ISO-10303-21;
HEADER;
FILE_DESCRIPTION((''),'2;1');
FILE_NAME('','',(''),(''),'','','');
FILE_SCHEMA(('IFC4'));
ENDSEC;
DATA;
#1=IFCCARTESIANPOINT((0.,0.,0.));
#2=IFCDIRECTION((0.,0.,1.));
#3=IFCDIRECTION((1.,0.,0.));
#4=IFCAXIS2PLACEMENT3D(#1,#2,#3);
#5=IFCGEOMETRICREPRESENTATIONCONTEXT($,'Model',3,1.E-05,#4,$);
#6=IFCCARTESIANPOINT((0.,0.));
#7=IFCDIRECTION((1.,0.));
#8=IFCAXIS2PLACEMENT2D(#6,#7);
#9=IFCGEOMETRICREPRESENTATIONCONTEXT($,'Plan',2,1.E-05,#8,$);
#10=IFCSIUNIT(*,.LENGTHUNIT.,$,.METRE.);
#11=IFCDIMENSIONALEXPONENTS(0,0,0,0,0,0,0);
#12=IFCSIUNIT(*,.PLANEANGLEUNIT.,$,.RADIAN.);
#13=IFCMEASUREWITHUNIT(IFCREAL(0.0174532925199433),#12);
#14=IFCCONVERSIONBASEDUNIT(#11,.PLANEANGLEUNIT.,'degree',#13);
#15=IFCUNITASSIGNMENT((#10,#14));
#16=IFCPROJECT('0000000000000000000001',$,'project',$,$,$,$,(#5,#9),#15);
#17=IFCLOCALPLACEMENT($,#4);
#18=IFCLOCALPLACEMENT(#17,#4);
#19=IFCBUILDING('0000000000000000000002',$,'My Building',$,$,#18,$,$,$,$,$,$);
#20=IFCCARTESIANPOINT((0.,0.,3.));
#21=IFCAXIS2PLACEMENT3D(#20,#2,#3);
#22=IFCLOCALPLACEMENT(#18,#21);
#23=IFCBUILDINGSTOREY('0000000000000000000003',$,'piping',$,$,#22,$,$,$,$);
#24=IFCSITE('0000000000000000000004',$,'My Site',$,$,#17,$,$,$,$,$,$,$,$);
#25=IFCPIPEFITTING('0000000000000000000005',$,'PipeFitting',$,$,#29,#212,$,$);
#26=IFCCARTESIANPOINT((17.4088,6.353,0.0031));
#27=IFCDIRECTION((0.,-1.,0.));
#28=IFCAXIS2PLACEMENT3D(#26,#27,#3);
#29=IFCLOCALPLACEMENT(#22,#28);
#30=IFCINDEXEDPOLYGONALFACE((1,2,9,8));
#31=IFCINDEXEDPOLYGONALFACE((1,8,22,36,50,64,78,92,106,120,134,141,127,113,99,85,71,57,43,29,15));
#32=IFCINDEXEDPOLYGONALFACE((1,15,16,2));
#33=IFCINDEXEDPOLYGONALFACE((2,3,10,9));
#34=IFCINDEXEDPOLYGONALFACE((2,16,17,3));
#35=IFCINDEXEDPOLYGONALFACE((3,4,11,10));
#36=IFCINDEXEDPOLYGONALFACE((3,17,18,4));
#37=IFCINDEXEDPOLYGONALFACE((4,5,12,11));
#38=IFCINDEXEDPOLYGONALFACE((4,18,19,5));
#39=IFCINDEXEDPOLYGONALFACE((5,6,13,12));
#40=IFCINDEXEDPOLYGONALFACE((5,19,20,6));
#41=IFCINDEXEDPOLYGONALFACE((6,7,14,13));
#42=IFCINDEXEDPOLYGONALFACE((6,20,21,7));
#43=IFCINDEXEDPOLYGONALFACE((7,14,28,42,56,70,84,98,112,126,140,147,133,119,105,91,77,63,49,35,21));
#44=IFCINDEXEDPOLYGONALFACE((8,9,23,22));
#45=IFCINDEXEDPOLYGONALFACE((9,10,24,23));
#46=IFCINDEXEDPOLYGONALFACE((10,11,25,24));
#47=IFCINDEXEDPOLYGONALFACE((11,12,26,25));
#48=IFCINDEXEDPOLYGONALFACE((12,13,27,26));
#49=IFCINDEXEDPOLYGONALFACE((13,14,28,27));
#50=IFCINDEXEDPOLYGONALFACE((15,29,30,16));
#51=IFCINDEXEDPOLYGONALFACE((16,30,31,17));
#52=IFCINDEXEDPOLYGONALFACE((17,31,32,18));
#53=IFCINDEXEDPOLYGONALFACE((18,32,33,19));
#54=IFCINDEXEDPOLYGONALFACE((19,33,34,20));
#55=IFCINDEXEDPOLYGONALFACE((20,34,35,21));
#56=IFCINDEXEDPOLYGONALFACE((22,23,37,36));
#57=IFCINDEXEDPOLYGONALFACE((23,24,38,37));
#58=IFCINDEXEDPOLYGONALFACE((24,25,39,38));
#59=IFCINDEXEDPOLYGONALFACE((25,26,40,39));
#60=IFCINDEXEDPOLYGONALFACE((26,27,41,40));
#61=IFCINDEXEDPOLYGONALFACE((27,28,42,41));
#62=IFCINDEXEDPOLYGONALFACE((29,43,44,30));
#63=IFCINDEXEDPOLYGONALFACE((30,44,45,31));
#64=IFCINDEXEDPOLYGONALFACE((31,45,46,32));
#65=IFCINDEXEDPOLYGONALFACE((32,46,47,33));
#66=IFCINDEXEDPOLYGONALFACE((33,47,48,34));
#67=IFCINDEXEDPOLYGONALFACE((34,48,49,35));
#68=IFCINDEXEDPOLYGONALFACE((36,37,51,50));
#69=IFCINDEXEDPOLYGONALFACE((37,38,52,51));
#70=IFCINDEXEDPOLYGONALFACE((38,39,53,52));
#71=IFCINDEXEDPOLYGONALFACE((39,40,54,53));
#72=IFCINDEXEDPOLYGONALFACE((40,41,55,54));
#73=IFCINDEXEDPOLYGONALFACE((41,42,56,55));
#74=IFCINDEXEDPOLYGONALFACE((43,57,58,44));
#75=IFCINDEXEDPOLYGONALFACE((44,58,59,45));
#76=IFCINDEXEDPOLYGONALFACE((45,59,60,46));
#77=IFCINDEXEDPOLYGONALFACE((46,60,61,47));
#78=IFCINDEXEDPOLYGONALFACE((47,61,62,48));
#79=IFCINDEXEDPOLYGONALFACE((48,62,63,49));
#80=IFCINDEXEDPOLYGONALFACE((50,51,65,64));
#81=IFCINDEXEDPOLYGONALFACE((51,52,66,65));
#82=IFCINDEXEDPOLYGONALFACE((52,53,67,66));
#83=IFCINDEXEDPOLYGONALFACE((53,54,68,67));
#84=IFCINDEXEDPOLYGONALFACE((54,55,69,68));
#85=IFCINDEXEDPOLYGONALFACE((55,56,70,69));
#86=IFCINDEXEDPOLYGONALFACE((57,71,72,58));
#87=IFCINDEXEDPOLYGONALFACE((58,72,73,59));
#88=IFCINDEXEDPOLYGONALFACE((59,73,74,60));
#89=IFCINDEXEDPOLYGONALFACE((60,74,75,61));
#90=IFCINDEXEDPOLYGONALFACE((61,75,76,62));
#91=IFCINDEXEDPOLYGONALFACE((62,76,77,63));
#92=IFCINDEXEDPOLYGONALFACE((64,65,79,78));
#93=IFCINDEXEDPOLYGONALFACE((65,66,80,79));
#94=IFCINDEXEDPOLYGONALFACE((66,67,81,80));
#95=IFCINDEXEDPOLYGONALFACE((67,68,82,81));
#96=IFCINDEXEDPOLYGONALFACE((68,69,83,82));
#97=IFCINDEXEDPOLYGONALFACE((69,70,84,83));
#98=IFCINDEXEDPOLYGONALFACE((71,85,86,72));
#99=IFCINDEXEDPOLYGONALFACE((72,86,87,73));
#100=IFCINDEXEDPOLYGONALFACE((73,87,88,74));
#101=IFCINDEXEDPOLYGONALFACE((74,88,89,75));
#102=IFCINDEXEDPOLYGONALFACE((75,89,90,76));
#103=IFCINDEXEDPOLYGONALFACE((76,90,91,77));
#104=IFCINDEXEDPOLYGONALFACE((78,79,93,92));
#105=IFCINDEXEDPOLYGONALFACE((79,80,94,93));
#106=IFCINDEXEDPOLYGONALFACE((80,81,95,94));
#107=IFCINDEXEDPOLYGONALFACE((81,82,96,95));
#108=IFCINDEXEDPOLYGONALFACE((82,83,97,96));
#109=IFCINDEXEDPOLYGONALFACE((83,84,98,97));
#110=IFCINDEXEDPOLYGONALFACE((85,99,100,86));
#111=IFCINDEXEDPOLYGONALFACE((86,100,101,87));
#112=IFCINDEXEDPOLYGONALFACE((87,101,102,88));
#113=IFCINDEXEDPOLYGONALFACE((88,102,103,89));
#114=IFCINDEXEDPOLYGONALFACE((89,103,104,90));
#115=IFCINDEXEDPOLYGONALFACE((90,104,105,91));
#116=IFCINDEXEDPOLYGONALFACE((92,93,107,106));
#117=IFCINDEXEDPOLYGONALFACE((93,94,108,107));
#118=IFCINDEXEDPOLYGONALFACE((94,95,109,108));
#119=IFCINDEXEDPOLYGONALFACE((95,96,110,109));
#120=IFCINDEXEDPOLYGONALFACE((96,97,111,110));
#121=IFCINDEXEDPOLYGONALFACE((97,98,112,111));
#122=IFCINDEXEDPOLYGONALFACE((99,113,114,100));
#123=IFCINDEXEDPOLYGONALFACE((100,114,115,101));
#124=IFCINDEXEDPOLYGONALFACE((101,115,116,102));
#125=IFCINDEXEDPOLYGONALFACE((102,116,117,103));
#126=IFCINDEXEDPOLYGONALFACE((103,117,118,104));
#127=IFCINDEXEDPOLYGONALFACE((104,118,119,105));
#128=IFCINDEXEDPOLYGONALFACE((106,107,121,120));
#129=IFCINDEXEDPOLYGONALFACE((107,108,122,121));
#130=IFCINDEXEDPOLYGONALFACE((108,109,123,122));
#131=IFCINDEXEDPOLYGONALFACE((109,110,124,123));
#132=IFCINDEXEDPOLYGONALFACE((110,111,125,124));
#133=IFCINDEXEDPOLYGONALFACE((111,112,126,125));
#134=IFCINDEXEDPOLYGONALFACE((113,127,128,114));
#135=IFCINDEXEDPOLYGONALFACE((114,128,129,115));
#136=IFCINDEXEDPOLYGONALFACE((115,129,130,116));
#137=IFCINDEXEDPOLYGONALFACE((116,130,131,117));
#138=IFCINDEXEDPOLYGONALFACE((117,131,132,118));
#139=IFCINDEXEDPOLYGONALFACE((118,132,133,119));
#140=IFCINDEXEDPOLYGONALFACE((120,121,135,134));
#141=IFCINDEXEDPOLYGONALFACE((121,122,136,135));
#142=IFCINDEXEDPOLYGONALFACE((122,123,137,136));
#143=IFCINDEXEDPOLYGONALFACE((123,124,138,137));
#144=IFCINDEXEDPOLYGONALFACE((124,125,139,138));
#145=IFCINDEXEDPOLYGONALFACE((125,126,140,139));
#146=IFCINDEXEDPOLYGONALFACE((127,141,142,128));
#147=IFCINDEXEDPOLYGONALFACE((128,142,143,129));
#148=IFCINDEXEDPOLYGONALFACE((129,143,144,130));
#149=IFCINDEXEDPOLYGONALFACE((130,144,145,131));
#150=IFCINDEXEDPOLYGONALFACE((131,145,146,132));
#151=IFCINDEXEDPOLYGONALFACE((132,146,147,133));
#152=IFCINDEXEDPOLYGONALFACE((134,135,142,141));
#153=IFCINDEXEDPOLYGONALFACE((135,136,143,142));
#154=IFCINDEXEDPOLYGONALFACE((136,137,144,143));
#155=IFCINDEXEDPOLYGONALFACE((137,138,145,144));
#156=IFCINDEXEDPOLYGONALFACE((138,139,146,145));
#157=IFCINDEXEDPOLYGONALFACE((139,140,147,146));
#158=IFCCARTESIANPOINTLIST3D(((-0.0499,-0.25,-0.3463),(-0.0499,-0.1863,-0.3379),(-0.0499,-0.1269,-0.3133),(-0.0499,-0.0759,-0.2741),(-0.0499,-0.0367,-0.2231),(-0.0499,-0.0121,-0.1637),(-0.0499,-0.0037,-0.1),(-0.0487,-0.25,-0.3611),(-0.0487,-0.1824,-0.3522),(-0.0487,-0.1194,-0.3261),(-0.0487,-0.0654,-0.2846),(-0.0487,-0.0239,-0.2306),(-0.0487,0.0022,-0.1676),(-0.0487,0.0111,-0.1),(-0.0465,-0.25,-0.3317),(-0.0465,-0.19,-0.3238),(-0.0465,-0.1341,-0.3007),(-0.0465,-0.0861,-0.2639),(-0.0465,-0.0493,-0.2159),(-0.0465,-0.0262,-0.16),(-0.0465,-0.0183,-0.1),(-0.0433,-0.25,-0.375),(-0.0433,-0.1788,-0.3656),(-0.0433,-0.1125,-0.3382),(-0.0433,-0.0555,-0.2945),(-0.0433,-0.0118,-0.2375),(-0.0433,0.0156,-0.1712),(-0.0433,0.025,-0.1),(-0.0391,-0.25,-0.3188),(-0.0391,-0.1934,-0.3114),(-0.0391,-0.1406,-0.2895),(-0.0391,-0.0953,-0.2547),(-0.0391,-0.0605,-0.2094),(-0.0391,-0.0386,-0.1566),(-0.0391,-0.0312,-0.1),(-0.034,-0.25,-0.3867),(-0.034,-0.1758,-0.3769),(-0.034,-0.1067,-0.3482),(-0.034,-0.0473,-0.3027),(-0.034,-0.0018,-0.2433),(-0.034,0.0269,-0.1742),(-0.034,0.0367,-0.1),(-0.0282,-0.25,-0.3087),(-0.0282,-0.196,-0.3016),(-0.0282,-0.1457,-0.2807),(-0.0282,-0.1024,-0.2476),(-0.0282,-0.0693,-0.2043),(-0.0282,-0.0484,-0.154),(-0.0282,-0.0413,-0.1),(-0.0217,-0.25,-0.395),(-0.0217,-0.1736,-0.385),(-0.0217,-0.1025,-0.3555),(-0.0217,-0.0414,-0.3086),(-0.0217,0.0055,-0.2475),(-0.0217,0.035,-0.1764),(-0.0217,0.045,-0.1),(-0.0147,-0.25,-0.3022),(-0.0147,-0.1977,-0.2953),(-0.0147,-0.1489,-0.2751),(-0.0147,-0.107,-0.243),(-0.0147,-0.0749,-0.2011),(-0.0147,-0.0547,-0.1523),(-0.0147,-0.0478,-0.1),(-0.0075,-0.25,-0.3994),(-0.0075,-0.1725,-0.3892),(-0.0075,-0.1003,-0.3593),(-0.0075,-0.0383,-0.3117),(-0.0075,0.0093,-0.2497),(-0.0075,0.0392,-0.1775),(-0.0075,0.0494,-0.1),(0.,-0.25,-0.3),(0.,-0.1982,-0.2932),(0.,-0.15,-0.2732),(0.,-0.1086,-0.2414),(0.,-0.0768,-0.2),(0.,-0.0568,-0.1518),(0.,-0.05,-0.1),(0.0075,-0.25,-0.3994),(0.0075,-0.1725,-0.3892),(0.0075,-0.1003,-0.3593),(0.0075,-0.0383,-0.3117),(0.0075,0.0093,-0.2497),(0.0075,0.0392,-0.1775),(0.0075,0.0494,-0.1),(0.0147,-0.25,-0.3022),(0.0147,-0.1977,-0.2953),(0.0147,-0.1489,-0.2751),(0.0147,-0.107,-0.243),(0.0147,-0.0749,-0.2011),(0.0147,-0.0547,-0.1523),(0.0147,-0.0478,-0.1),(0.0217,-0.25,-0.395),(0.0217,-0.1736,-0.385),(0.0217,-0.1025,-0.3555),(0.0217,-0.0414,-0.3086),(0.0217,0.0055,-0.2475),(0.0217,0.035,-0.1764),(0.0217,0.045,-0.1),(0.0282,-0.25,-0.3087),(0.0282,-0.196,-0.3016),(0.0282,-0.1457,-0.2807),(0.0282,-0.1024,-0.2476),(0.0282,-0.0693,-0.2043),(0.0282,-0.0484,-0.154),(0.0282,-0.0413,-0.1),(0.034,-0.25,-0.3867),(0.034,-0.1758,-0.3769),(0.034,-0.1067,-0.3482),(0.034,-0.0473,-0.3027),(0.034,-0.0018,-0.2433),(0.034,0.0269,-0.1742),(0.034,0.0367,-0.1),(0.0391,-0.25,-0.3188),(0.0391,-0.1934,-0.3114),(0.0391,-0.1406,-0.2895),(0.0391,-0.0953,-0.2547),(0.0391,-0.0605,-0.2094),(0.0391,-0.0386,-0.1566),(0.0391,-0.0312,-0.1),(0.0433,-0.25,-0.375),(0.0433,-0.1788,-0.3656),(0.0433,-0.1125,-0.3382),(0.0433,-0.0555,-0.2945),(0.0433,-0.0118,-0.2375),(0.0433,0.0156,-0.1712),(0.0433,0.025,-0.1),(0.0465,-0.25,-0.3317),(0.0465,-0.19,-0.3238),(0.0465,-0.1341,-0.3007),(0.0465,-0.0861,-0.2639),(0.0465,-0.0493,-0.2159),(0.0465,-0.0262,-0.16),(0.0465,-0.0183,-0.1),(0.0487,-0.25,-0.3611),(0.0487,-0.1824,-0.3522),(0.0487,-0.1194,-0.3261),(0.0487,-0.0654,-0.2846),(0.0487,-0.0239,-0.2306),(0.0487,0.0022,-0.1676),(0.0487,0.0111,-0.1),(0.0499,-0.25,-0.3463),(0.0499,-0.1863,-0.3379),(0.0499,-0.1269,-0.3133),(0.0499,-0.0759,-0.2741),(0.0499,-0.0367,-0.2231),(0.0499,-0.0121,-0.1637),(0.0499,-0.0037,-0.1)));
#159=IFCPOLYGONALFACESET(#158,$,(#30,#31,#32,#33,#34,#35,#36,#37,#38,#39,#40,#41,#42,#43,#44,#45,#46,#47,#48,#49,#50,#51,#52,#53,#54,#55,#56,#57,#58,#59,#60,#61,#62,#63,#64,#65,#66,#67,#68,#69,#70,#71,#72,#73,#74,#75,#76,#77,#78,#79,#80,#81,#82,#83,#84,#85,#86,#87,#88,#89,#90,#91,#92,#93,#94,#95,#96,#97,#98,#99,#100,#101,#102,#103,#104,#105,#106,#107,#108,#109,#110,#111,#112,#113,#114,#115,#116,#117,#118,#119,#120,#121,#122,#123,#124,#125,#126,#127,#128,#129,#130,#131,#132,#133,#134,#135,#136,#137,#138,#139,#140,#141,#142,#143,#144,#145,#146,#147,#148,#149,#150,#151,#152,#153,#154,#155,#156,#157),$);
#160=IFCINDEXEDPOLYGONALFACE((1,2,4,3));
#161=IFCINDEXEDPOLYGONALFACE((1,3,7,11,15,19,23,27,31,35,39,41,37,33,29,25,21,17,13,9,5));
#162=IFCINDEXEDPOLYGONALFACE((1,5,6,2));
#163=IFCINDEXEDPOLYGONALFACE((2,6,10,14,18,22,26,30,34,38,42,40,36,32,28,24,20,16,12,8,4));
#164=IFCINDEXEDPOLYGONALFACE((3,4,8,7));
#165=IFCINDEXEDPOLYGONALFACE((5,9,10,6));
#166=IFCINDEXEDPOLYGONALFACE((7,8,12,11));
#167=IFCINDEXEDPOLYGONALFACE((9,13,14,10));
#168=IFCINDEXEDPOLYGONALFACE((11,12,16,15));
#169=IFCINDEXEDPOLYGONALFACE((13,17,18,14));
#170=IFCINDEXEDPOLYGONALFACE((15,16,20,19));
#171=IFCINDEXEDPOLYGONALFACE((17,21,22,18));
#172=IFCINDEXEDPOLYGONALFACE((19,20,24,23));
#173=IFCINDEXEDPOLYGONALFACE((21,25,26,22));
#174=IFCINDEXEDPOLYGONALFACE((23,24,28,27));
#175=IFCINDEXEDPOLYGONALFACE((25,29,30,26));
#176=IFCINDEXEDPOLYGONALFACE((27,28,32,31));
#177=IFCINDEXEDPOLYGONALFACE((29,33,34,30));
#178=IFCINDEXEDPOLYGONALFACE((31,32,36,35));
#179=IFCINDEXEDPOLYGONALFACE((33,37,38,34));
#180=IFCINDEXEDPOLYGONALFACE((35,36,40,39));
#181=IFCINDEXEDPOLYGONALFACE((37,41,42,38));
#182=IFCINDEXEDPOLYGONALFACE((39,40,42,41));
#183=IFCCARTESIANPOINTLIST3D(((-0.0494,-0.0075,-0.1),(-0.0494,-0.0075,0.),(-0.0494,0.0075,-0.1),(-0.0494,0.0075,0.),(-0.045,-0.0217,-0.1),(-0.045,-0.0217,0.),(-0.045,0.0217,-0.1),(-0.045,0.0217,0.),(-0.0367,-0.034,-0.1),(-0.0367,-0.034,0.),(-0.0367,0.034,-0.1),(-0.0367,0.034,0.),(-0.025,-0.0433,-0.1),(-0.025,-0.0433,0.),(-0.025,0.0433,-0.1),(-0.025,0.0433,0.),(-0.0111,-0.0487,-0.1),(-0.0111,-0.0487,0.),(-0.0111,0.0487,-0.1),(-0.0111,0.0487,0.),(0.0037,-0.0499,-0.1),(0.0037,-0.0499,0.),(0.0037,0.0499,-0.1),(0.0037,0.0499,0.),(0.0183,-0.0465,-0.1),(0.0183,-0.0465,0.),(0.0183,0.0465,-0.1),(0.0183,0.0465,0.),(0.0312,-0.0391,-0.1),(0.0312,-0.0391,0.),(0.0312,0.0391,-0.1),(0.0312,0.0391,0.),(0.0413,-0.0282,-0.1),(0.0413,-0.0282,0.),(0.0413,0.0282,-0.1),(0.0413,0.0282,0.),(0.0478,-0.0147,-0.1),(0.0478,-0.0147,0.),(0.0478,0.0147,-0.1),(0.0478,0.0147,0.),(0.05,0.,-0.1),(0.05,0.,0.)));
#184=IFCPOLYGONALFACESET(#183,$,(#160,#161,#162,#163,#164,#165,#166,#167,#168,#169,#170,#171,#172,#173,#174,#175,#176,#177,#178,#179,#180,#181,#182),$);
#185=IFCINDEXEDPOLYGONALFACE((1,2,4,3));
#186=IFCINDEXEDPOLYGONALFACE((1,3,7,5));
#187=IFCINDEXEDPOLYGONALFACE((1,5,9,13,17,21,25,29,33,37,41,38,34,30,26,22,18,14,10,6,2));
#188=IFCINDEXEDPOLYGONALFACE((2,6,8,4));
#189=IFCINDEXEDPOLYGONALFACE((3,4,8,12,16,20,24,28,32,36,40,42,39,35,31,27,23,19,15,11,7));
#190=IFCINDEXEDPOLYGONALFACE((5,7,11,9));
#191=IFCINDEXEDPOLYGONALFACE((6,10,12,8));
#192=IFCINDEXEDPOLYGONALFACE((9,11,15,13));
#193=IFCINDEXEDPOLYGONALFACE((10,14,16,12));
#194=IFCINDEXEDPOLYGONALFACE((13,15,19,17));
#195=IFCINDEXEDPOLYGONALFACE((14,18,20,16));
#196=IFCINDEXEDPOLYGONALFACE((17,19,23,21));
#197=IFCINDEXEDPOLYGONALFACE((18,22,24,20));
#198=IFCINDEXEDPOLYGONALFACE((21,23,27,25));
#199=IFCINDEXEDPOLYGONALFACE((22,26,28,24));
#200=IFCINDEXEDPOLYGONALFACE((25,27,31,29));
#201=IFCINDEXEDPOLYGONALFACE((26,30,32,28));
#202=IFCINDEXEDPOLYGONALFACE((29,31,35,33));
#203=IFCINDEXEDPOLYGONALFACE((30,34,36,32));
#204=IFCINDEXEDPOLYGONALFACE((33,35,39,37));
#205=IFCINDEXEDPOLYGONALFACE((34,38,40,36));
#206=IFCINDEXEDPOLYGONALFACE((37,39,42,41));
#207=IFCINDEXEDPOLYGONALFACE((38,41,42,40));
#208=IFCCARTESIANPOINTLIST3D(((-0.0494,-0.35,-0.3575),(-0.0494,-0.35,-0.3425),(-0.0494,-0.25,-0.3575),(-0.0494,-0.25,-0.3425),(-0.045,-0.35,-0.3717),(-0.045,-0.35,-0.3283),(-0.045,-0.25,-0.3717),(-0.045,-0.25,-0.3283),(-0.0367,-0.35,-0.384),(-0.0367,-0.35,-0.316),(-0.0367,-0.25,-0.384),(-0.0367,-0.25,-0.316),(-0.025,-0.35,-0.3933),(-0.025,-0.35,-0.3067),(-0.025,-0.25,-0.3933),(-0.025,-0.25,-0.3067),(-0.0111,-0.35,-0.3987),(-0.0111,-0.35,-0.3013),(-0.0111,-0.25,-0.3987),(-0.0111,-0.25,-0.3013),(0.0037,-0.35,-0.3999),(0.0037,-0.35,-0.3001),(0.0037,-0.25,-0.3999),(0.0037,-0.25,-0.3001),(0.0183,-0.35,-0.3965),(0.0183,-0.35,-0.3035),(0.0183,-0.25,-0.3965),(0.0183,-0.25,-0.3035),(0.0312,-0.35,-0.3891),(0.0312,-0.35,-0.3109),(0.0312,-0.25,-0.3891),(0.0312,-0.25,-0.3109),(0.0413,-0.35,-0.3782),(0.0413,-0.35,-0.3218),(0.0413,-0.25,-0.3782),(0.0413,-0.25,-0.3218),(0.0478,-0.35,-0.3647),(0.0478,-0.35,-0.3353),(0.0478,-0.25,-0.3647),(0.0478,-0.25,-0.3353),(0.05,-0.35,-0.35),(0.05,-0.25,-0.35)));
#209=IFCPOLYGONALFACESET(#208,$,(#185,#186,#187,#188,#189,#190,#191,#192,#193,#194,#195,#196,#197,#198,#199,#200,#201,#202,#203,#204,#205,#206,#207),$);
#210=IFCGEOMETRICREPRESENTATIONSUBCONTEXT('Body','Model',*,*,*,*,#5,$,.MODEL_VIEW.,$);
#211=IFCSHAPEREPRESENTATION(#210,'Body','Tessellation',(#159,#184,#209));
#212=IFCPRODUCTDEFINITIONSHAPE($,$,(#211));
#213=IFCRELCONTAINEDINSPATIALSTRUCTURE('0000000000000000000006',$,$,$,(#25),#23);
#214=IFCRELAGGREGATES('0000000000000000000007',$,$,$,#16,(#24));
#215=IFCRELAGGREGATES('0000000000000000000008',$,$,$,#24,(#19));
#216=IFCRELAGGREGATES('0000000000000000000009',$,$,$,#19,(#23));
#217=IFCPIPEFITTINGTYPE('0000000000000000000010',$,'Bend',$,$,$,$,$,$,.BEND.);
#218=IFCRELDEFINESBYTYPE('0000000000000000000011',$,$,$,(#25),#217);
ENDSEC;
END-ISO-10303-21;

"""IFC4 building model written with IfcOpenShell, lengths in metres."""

from ifc_helpers import new_model, entity, si_unit, converted_unit, frame, origin_with_axes, origin_2d_with_axis, place, context, subcontext, project, spatial, circle, extrude, source, transform, mapped, type_object, type_shapes, element, save


model = new_model("IFC4")

# Units and contexts
model_context = context("Model", 3, precision=1e-05, world=origin_with_axes())
plan_context = context("Plan", 2, precision=1e-05, world=origin_2d_with_axis())
body_context = subcontext(model_context, "Body", "Model", "MODEL_VIEW")
ifc_project = project(units=[si_unit("LENGTHUNIT", "METRE"), converted_unit("PLANEANGLEUNIT", "degree", entity("IfcReal", 0.0174532925199433), si_unit("PLANEANGLEUNIT", "RADIAN"), dimensions=[0, 0, 0, 0, 0, 0, 0])], contexts=[model_context, plan_context])

# Site, building, storey
site_placement = place(None, origin_with_axes())
site = spatial("IfcSite", under=ifc_project, at=site_placement, Name="My Site")
building_placement = place(site_placement, origin_with_axes())
building = spatial("IfcBuilding", under=site, at=building_placement, Name="My Building")
storey_placement = place(building_placement, frame((0.0, 0.0, 3.0), z_axis=(0.0, 0.0, 1.0), x_axis=(1.0, 0.0, 0.0)))
storey = spatial("IfcBuildingStorey", under=building, at=storey_placement, Name="piping")

# Pipe fitting
pipe_fitting_type = type_object("IfcPipeFittingType", Name="Bend", PredefinedType="BEND")
shared_shape = source(origin_with_axes(), body_context, "Body", "SolidModel", [
    entity("IfcSweptDiskSolid", entity("IfcIndexedPolyCurve", entity("IfcCartesianPointList3D", [[0.0, 0.0, -0.1], [0.0, -0.0732, -0.2768], [0.0, -0.25, -0.35]]), [entity("IfcArcIndex", [1, 2, 3])]), 0.05),
    extrude(circle(Radius=0.05), origin_with_axes(), (0.0, 0.0, -1.0), 0.1),
    extrude(circle(Radius=0.05), frame((0.0, -0.25, -0.35), z_axis=(0.0, -1.0, 0.0), x_axis=(1.0, 0.0, 0.0)), (0.0, 0.0, 1.0), 0.1),
])
type_shapes(pipe_fitting_type, [shared_shape])
for number, where, z_axis, x_axis, name in (
    (1, (17.4088, 6.353, 0.0031), (0.0, -1.0, 0.0), (1.0, 0.0, 0.0), "PipeFitting"),
):
    element("IfcPipeFitting", number, at=place(storey_placement, frame(where, z_axis=z_axis, x_axis=x_axis)), inside=storey, type_object=pipe_fitting_type, Name=name, context=body_context, shape_type="MappedRepresentation", body=[
        mapped(shared_shape, transform((0.0, 0.0, 0.0), x_axis=(1.0, 0.0, 0.0), y_axis=(0.0, 1.0, 0.0), z_axis=(0.0, 0.0, 1.0), scale=1.0)),
    ])

save(model, "model.ifc")
